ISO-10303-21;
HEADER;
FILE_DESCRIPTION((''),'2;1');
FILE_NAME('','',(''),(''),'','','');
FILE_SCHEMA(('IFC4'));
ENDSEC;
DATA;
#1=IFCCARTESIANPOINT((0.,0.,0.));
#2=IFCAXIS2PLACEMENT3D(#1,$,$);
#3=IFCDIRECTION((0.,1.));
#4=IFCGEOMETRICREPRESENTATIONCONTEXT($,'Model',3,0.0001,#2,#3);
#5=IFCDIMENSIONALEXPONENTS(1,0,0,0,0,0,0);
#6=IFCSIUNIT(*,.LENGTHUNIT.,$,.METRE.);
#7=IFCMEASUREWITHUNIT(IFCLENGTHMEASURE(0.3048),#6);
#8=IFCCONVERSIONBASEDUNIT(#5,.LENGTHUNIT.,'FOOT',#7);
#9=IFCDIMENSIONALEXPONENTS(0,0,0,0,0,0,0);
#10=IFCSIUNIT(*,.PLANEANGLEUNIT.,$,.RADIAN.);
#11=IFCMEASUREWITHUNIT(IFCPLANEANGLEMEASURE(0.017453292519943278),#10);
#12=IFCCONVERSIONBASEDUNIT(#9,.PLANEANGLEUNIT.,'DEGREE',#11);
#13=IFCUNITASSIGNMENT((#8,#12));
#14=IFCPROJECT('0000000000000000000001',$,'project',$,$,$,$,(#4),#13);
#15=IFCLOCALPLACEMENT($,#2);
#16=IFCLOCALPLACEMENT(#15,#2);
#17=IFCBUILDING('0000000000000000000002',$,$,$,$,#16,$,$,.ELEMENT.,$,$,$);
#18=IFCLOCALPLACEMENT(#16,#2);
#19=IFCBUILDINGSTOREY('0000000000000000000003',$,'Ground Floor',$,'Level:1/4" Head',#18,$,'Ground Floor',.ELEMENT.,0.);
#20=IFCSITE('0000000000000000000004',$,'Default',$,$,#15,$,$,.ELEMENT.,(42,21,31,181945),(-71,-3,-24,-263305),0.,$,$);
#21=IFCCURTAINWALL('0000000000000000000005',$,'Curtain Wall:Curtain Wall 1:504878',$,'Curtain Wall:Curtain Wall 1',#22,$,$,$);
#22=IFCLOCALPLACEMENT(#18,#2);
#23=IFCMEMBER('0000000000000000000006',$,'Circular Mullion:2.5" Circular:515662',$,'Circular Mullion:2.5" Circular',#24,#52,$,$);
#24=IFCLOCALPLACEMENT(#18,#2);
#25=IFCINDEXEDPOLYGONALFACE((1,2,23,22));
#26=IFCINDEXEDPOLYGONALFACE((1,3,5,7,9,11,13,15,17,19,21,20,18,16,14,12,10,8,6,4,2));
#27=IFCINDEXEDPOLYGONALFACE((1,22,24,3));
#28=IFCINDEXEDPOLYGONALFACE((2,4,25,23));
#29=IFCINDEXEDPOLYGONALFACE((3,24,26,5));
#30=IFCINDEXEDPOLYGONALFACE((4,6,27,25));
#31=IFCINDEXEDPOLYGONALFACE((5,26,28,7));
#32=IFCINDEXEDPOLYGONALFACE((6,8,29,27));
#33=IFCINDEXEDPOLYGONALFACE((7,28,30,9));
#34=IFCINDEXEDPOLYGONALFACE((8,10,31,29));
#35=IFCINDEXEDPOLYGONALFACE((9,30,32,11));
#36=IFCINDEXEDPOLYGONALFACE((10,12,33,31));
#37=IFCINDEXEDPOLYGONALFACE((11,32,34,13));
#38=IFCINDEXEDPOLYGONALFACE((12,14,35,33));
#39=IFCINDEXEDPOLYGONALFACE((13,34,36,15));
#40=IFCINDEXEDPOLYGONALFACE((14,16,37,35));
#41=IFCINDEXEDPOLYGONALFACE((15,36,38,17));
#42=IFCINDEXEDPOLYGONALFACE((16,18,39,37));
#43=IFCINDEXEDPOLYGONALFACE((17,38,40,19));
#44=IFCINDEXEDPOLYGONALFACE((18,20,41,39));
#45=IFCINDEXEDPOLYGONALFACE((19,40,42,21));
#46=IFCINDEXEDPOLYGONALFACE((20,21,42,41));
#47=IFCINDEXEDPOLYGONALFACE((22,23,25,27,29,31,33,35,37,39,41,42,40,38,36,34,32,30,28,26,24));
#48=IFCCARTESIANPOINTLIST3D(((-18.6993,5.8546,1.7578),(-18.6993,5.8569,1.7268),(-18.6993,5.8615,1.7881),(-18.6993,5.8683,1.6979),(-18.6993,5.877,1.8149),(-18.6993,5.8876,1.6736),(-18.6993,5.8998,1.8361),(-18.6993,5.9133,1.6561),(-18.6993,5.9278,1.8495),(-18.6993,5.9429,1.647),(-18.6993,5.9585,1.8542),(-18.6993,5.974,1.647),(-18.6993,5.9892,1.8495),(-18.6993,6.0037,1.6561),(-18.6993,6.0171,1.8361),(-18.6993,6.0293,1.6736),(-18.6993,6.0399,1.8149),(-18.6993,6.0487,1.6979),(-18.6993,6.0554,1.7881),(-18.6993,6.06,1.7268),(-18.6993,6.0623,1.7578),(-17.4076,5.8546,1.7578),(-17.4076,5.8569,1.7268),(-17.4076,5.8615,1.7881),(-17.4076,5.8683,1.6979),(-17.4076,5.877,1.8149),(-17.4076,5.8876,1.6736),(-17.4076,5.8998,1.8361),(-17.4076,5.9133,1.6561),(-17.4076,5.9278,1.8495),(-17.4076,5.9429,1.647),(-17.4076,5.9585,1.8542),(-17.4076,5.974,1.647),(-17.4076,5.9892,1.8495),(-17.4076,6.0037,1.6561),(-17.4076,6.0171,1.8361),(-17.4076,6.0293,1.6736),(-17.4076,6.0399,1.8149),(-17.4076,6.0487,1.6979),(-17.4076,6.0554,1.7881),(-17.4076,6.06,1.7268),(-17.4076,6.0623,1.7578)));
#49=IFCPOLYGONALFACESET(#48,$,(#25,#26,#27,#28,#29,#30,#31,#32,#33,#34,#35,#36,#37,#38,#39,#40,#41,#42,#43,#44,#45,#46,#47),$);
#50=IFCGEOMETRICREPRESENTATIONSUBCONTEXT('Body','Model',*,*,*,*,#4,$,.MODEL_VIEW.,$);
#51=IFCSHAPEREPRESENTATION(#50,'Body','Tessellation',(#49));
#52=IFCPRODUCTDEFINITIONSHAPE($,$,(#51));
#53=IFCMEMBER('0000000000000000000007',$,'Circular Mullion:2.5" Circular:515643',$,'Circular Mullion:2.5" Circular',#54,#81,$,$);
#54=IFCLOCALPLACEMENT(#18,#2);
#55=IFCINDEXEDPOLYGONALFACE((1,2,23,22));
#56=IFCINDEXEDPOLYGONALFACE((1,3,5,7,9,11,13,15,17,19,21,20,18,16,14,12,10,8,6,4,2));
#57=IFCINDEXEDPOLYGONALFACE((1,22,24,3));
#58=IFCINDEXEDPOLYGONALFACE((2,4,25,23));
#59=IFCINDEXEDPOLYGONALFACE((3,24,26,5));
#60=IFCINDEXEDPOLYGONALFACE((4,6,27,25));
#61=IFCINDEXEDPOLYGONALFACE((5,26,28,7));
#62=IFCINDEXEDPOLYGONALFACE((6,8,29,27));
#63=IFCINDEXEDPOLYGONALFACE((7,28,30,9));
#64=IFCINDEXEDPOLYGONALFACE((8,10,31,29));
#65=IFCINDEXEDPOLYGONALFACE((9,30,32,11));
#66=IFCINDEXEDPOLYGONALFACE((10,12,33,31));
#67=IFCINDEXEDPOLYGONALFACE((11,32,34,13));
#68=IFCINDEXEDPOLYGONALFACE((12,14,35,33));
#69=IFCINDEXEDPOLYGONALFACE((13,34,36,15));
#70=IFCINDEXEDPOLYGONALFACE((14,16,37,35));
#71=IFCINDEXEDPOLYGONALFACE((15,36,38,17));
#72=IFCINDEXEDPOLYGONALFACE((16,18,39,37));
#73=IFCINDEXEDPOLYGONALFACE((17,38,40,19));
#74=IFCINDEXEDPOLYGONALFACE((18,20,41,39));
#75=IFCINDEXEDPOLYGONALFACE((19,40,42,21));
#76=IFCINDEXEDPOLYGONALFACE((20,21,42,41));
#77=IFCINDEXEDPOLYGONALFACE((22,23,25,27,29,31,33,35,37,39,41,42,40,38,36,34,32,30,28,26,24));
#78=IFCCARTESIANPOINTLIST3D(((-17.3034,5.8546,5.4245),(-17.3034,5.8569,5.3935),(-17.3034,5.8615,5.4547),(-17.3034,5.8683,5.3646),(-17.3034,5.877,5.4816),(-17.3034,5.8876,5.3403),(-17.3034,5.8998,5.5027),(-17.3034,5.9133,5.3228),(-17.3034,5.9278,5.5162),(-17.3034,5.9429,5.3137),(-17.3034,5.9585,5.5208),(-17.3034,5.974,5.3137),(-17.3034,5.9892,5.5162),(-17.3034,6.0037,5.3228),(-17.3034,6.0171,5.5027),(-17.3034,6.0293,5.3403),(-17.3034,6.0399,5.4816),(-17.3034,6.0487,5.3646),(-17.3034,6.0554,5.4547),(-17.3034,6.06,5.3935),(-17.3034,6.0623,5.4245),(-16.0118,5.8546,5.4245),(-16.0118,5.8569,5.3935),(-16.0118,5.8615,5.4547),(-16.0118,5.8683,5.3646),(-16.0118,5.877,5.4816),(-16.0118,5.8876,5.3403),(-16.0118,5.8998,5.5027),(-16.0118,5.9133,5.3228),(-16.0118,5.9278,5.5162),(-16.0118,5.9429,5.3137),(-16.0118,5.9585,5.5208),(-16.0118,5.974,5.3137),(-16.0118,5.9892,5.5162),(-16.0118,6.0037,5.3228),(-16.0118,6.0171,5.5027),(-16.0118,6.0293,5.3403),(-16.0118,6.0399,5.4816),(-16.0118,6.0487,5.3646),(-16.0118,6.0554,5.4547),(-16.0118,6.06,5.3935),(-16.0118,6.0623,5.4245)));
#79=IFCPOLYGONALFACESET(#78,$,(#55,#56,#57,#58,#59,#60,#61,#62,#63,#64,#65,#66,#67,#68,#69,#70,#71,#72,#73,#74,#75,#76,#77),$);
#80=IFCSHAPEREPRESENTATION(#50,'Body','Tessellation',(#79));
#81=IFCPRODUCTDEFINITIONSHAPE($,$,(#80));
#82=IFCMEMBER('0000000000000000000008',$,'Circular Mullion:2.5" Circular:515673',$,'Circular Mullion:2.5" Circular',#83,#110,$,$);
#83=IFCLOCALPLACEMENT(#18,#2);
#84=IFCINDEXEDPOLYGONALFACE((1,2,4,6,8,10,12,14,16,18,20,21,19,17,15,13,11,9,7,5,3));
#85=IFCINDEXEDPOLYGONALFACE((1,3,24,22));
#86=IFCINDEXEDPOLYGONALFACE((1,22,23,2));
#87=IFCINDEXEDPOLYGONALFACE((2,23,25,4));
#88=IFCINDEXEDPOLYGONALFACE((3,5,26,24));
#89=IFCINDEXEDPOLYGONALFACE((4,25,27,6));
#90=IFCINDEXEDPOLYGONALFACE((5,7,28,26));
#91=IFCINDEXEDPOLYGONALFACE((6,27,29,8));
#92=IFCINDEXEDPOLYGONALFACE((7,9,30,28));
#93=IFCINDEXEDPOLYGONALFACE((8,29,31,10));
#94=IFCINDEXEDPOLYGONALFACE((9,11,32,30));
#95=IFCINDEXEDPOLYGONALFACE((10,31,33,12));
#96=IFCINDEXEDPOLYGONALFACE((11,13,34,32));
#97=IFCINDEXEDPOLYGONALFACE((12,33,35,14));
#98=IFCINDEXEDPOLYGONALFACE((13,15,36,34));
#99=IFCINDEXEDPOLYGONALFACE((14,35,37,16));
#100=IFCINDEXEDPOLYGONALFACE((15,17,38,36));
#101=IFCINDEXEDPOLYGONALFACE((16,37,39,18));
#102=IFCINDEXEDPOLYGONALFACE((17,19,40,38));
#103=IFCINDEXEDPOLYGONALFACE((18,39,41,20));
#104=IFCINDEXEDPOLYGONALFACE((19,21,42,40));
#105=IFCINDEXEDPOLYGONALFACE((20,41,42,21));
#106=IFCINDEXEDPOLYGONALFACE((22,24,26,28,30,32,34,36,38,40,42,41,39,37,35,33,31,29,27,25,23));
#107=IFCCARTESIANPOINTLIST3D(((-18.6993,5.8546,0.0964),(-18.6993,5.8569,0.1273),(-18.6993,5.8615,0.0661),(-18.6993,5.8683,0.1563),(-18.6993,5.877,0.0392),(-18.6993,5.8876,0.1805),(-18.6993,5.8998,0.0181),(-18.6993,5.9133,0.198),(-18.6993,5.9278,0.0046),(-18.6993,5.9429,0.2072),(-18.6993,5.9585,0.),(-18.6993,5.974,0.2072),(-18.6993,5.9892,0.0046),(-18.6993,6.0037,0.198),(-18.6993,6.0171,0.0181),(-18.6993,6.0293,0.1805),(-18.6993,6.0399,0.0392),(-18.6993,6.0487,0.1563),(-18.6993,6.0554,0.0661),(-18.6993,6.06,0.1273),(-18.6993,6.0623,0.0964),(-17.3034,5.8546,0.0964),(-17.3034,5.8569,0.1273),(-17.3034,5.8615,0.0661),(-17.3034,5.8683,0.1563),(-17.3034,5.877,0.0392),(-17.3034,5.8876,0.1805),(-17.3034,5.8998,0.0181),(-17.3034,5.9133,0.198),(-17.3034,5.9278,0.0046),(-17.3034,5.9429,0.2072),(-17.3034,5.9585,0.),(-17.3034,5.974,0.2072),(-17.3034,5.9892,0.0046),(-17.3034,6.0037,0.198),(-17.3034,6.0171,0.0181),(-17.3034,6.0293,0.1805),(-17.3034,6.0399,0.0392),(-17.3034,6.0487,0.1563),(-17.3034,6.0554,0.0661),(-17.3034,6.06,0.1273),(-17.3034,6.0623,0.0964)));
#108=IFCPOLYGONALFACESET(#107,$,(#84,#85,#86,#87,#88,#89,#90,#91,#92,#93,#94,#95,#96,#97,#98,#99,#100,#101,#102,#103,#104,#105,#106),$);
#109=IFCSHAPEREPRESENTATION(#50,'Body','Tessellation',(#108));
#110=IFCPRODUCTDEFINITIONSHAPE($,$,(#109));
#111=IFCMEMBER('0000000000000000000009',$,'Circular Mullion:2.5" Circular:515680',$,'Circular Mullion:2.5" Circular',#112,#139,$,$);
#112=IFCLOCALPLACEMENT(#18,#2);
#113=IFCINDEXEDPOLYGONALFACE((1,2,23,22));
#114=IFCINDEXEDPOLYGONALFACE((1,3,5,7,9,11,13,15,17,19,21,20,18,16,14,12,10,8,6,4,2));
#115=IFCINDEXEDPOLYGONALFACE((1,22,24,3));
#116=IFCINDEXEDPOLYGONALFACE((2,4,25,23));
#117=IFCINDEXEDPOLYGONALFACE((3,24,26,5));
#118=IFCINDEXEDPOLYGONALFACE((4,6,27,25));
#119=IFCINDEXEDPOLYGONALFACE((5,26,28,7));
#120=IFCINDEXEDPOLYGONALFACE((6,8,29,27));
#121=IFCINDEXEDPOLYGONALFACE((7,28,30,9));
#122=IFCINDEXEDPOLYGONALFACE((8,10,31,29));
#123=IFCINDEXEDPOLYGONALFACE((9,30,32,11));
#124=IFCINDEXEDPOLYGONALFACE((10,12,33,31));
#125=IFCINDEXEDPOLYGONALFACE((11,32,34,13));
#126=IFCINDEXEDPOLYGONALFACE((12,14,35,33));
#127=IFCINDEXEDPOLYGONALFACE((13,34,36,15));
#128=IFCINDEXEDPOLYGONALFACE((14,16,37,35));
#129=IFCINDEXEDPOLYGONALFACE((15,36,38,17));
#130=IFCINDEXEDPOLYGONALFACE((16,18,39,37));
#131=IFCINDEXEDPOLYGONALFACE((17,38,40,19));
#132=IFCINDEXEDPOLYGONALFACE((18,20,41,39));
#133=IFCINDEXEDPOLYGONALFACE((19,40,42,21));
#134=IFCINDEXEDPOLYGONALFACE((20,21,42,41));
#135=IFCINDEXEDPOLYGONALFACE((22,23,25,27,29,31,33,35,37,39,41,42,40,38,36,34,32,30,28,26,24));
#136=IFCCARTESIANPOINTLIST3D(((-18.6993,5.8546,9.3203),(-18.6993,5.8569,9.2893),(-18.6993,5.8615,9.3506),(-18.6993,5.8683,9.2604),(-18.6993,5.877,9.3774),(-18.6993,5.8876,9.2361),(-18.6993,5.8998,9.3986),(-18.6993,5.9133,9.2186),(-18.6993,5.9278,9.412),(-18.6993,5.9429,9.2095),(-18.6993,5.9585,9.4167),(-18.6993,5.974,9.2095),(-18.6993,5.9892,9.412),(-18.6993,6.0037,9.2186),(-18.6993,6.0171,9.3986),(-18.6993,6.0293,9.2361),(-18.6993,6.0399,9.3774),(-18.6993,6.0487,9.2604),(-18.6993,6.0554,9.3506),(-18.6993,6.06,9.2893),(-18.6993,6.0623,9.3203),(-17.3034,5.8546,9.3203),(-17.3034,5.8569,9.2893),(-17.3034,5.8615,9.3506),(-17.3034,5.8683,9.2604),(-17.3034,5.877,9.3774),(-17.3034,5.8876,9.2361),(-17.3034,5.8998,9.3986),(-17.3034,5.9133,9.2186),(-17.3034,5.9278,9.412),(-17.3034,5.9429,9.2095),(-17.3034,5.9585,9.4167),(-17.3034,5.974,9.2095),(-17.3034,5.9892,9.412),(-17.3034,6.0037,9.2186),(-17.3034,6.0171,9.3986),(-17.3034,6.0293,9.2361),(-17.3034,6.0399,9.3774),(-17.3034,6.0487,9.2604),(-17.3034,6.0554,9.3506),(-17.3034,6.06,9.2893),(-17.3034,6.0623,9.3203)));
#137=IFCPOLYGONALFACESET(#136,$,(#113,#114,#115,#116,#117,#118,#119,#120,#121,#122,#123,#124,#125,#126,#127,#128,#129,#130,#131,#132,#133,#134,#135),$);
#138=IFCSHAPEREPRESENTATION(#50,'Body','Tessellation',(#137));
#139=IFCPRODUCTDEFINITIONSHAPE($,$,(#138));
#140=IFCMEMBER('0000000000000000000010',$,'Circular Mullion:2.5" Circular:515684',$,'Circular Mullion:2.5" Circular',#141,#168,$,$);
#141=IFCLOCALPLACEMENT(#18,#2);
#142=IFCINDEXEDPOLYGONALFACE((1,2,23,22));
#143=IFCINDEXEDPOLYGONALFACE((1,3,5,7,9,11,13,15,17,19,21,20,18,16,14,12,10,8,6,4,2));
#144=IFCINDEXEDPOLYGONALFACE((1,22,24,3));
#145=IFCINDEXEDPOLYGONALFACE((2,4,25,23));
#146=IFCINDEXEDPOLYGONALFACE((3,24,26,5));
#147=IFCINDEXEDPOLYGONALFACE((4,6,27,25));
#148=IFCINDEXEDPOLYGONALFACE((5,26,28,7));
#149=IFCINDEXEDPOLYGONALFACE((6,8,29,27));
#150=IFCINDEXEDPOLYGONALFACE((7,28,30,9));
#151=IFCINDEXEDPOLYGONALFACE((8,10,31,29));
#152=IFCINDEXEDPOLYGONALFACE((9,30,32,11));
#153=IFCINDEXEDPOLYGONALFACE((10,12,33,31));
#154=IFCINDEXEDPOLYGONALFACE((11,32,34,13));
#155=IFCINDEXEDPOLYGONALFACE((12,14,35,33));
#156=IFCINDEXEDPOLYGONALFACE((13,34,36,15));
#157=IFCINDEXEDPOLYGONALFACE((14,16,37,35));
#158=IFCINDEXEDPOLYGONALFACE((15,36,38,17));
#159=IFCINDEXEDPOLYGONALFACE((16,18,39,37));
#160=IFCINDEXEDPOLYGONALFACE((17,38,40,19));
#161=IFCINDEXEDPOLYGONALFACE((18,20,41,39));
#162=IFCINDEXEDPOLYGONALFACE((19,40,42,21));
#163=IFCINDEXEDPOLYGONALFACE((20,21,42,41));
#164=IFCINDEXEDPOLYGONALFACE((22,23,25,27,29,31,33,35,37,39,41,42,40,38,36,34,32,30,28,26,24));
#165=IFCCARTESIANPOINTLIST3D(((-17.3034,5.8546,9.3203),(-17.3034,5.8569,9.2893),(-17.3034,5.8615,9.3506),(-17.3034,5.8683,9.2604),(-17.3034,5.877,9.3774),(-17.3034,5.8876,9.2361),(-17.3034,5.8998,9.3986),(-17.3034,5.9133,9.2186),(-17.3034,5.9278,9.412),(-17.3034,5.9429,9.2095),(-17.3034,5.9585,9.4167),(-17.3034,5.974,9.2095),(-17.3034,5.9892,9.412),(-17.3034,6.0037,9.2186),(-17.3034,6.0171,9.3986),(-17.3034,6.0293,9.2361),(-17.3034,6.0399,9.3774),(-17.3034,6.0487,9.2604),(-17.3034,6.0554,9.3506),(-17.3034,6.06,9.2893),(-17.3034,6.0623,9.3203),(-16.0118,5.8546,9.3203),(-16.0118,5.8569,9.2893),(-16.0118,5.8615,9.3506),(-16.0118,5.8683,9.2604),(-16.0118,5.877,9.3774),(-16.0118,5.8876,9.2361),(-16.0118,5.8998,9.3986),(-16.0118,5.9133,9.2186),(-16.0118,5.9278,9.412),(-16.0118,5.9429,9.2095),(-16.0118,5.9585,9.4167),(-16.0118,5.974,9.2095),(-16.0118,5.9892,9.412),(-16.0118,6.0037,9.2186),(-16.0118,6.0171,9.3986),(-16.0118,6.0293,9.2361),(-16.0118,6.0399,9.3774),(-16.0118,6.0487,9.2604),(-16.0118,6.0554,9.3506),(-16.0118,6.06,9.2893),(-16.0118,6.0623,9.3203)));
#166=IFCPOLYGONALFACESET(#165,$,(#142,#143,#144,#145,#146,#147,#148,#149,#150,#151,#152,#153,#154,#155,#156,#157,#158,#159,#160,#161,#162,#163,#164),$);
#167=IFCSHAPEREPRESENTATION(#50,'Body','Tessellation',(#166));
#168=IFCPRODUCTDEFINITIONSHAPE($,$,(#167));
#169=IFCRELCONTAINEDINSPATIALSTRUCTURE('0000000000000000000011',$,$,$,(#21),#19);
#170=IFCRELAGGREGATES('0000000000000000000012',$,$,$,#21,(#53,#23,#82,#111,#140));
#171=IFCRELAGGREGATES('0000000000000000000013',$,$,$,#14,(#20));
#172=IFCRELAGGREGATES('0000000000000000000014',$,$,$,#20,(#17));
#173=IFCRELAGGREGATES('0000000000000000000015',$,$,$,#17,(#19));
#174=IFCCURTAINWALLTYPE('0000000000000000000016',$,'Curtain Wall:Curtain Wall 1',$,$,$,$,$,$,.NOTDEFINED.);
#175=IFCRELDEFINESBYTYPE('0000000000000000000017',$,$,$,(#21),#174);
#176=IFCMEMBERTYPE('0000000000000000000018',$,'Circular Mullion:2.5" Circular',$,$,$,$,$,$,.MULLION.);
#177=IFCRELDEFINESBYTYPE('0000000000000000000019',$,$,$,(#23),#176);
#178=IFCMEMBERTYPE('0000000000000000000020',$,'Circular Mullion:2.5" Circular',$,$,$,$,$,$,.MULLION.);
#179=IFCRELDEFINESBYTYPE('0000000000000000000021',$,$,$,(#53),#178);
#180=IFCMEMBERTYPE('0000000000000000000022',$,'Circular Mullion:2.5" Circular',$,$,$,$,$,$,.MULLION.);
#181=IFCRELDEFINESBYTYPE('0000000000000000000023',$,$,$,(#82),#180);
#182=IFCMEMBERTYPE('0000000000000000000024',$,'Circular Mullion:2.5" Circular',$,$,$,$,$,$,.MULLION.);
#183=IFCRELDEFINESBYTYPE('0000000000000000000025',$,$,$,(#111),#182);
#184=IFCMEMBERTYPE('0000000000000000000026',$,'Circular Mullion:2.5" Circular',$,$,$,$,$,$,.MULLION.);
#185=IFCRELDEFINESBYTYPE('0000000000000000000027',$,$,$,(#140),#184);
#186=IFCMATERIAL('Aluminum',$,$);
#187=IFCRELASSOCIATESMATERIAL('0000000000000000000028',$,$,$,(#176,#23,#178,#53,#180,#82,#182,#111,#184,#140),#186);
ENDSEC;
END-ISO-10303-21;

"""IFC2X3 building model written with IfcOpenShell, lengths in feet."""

from ifc_helpers import new_model, entity, si_unit, converted_unit, direction, frame, frame_2d, origin, place, context, subcontext, project, spatial, circle, extrude, source, transform, mapped, material, type_object, type_shapes, element, aggregate, save


model = new_model("IFC2X3")

# Units and contexts
model_context = context("Model", 3, precision=0.0001, world=origin(), true_north=direction((0.0, 1.0)))
body_context = subcontext(model_context, "Body", "Model", "MODEL_VIEW")
ifc_project = project(units=[converted_unit("LENGTHUNIT", "FOOT", entity("IfcLengthMeasure", 0.3048), si_unit("LENGTHUNIT", "METRE"), dimensions=[1, 0, 0, 0, 0, 0, 0]), converted_unit("PLANEANGLEUNIT", "DEGREE", entity("IfcPlaneAngleMeasure", 0.017453292519943278), si_unit("PLANEANGLEUNIT", "RADIAN"), dimensions=[0, 0, 0, 0, 0, 0, 0])], contexts=[model_context])

# Site, building, storey
site_placement = place(None, origin())
site = spatial("IfcSite", under=ifc_project, at=site_placement, Name="Default", CompositionType="ELEMENT", RefLatitude=(42, 21, 31, 181945), RefLongitude=(-71, -3, -24, -263305), RefElevation=0.0)
building_placement = place(site_placement, origin())
building = spatial("IfcBuilding", under=site, at=building_placement, CompositionType="ELEMENT")
storey_placement = place(building_placement, origin())
storey = spatial("IfcBuildingStorey", under=building, at=storey_placement, Name="Ground Floor", ObjectType="Level:1/4\" Head", LongName="Ground Floor", CompositionType="ELEMENT", Elevation=0.0)

# Curtain wall, members
curtain_wall_type = type_object("IfcCurtainWallType", Name="Curtain Wall:Curtain Wall 1", PredefinedType="NOTDEFINED")
curtain_wall_placement = place(storey_placement, origin())
curtain_wall = element("IfcCurtainWall", 1, at=curtain_wall_placement, inside=storey, type_object=curtain_wall_type, Name="Curtain Wall:Curtain Wall 1:504878", ObjectType="Curtain Wall:Curtain Wall 1")
ifc_material_1 = material(Name="Aluminum")
member_type_1 = type_object("IfcMemberType", Name="Circular Mullion:2.5\" Circular", PredefinedType="MULLION", material=ifc_material_1)
shared_shape_1 = source(origin(), body_context, "Body", "SweptSolid", [
    extrude(circle(Radius=0.1042, at=frame_2d((0.0, 0.0), x_axis=(1.0, 0.0))), frame((0.0, 0.0, -1.2917)), (0.0, 0.0, 1.0), 1.2917),
])
type_shapes(member_type_1, [shared_shape_1])
member_1_placement = place(curtain_wall_placement, frame((-18.6993, 5.9585, 1.75), z_axis=(-1.0, 0.0, 0.0), x_axis=(0.0, 0.0, 1.0)))
member_1 = element("IfcMember", 2, at=member_1_placement, type_object=member_type_1, material=ifc_material_1, Name="Circular Mullion:2.5\" Circular:515662", ObjectType="Circular Mullion:2.5\" Circular", context=body_context, shape_type="MappedRepresentation", body=[
    mapped(shared_shape_1, transform((0.0, 0.0, 0.0), scale=1.0)),
])
member_type_2 = type_object("IfcMemberType", Name="Circular Mullion:2.5\" Circular", PredefinedType="MULLION", material=ifc_material_1)
shared_shape_2 = source(origin(), body_context, "Body", "SweptSolid", [
    extrude(circle(Radius=0.1042, at=frame_2d((0.0, 0.0), x_axis=(1.0, 0.0))), frame((0.0, 0.0, -1.2917)), (0.0, 0.0, 1.0), 1.2917),
])
type_shapes(member_type_2, [shared_shape_2])
member_2_placement = place(curtain_wall_placement, frame((-17.3034, 5.9585, 5.4167), z_axis=(-1.0, 0.0, 0.0), x_axis=(0.0, 0.0, 1.0)))
member_2 = element("IfcMember", 3, at=member_2_placement, type_object=member_type_2, material=ifc_material_1, Name="Circular Mullion:2.5\" Circular:515643", ObjectType="Circular Mullion:2.5\" Circular", context=body_context, shape_type="MappedRepresentation", body=[
    mapped(shared_shape_2, transform((0.0, 0.0, 0.0), scale=1.0)),
])
member_type_3 = type_object("IfcMemberType", Name="Circular Mullion:2.5\" Circular", PredefinedType="MULLION", material=ifc_material_1)
shared_shape_3 = source(origin(), body_context, "Body", "SweptSolid", [
    extrude(circle(Radius=0.1042, at=frame_2d((0.0, 0.0), x_axis=(1.0, 0.0))), frame((-0.1042, 0.0, -1.3958)), (0.0, 0.0, 1.0), 1.3958),
])
type_shapes(member_type_3, [shared_shape_3])
member_3_placement = place(curtain_wall_placement, frame((-17.3034, 5.9585, 0.0), z_axis=(1.0, 0.0, 0.0), x_axis=(0.0, 0.0, -1.0)))
member_3 = element("IfcMember", 4, at=member_3_placement, type_object=member_type_3, material=ifc_material_1, Name="Circular Mullion:2.5\" Circular:515673", ObjectType="Circular Mullion:2.5\" Circular", context=body_context, shape_type="MappedRepresentation", body=[
    mapped(shared_shape_3, transform((0.0, 0.0, 0.0), scale=1.0)),
])
member_type_4 = type_object("IfcMemberType", Name="Circular Mullion:2.5\" Circular", PredefinedType="MULLION", material=ifc_material_1)
shared_shape_4 = source(origin(), body_context, "Body", "SweptSolid", [
    extrude(circle(Radius=0.1042, at=frame_2d((0.0, 0.0), x_axis=(1.0, 0.0))), frame((-0.1042, 0.0, -1.3958)), (0.0, 0.0, 1.0), 1.3958),
])
type_shapes(member_type_4, [shared_shape_4])
member_4_placement = place(curtain_wall_placement, frame((-18.6993, 5.9585, 9.4167), z_axis=(-1.0, 0.0, 0.0), x_axis=(0.0, 0.0, 1.0)))
member_4 = element("IfcMember", 5, at=member_4_placement, type_object=member_type_4, material=ifc_material_1, Name="Circular Mullion:2.5\" Circular:515680", ObjectType="Circular Mullion:2.5\" Circular", context=body_context, shape_type="MappedRepresentation", body=[
    mapped(shared_shape_4, transform((0.0, 0.0, 0.0), scale=1.0)),
])
member_type_5 = type_object("IfcMemberType", Name="Circular Mullion:2.5\" Circular", PredefinedType="MULLION", material=ifc_material_1)
shared_shape_5 = source(origin(), body_context, "Body", "SweptSolid", [
    extrude(circle(Radius=0.1042, at=frame_2d((0.0, 0.0), x_axis=(1.0, 0.0))), frame((-0.1042, 0.0, -1.2917)), (0.0, 0.0, 1.0), 1.2917),
])
type_shapes(member_type_5, [shared_shape_5])
member_5_placement = place(curtain_wall_placement, frame((-17.3034, 5.9585, 9.4167), z_axis=(-1.0, 0.0, 0.0), x_axis=(0.0, 0.0, 1.0)))
member_5 = element("IfcMember", 6, at=member_5_placement, type_object=member_type_5, material=ifc_material_1, Name="Circular Mullion:2.5\" Circular:515684", ObjectType="Circular Mullion:2.5\" Circular", context=body_context, shape_type="MappedRepresentation", body=[
    mapped(shared_shape_5, transform((0.0, 0.0, 0.0), scale=1.0)),
])
aggregate(curtain_wall, [member_2, member_1, member_3, member_4, member_5])

save(model, "model.ifc")
